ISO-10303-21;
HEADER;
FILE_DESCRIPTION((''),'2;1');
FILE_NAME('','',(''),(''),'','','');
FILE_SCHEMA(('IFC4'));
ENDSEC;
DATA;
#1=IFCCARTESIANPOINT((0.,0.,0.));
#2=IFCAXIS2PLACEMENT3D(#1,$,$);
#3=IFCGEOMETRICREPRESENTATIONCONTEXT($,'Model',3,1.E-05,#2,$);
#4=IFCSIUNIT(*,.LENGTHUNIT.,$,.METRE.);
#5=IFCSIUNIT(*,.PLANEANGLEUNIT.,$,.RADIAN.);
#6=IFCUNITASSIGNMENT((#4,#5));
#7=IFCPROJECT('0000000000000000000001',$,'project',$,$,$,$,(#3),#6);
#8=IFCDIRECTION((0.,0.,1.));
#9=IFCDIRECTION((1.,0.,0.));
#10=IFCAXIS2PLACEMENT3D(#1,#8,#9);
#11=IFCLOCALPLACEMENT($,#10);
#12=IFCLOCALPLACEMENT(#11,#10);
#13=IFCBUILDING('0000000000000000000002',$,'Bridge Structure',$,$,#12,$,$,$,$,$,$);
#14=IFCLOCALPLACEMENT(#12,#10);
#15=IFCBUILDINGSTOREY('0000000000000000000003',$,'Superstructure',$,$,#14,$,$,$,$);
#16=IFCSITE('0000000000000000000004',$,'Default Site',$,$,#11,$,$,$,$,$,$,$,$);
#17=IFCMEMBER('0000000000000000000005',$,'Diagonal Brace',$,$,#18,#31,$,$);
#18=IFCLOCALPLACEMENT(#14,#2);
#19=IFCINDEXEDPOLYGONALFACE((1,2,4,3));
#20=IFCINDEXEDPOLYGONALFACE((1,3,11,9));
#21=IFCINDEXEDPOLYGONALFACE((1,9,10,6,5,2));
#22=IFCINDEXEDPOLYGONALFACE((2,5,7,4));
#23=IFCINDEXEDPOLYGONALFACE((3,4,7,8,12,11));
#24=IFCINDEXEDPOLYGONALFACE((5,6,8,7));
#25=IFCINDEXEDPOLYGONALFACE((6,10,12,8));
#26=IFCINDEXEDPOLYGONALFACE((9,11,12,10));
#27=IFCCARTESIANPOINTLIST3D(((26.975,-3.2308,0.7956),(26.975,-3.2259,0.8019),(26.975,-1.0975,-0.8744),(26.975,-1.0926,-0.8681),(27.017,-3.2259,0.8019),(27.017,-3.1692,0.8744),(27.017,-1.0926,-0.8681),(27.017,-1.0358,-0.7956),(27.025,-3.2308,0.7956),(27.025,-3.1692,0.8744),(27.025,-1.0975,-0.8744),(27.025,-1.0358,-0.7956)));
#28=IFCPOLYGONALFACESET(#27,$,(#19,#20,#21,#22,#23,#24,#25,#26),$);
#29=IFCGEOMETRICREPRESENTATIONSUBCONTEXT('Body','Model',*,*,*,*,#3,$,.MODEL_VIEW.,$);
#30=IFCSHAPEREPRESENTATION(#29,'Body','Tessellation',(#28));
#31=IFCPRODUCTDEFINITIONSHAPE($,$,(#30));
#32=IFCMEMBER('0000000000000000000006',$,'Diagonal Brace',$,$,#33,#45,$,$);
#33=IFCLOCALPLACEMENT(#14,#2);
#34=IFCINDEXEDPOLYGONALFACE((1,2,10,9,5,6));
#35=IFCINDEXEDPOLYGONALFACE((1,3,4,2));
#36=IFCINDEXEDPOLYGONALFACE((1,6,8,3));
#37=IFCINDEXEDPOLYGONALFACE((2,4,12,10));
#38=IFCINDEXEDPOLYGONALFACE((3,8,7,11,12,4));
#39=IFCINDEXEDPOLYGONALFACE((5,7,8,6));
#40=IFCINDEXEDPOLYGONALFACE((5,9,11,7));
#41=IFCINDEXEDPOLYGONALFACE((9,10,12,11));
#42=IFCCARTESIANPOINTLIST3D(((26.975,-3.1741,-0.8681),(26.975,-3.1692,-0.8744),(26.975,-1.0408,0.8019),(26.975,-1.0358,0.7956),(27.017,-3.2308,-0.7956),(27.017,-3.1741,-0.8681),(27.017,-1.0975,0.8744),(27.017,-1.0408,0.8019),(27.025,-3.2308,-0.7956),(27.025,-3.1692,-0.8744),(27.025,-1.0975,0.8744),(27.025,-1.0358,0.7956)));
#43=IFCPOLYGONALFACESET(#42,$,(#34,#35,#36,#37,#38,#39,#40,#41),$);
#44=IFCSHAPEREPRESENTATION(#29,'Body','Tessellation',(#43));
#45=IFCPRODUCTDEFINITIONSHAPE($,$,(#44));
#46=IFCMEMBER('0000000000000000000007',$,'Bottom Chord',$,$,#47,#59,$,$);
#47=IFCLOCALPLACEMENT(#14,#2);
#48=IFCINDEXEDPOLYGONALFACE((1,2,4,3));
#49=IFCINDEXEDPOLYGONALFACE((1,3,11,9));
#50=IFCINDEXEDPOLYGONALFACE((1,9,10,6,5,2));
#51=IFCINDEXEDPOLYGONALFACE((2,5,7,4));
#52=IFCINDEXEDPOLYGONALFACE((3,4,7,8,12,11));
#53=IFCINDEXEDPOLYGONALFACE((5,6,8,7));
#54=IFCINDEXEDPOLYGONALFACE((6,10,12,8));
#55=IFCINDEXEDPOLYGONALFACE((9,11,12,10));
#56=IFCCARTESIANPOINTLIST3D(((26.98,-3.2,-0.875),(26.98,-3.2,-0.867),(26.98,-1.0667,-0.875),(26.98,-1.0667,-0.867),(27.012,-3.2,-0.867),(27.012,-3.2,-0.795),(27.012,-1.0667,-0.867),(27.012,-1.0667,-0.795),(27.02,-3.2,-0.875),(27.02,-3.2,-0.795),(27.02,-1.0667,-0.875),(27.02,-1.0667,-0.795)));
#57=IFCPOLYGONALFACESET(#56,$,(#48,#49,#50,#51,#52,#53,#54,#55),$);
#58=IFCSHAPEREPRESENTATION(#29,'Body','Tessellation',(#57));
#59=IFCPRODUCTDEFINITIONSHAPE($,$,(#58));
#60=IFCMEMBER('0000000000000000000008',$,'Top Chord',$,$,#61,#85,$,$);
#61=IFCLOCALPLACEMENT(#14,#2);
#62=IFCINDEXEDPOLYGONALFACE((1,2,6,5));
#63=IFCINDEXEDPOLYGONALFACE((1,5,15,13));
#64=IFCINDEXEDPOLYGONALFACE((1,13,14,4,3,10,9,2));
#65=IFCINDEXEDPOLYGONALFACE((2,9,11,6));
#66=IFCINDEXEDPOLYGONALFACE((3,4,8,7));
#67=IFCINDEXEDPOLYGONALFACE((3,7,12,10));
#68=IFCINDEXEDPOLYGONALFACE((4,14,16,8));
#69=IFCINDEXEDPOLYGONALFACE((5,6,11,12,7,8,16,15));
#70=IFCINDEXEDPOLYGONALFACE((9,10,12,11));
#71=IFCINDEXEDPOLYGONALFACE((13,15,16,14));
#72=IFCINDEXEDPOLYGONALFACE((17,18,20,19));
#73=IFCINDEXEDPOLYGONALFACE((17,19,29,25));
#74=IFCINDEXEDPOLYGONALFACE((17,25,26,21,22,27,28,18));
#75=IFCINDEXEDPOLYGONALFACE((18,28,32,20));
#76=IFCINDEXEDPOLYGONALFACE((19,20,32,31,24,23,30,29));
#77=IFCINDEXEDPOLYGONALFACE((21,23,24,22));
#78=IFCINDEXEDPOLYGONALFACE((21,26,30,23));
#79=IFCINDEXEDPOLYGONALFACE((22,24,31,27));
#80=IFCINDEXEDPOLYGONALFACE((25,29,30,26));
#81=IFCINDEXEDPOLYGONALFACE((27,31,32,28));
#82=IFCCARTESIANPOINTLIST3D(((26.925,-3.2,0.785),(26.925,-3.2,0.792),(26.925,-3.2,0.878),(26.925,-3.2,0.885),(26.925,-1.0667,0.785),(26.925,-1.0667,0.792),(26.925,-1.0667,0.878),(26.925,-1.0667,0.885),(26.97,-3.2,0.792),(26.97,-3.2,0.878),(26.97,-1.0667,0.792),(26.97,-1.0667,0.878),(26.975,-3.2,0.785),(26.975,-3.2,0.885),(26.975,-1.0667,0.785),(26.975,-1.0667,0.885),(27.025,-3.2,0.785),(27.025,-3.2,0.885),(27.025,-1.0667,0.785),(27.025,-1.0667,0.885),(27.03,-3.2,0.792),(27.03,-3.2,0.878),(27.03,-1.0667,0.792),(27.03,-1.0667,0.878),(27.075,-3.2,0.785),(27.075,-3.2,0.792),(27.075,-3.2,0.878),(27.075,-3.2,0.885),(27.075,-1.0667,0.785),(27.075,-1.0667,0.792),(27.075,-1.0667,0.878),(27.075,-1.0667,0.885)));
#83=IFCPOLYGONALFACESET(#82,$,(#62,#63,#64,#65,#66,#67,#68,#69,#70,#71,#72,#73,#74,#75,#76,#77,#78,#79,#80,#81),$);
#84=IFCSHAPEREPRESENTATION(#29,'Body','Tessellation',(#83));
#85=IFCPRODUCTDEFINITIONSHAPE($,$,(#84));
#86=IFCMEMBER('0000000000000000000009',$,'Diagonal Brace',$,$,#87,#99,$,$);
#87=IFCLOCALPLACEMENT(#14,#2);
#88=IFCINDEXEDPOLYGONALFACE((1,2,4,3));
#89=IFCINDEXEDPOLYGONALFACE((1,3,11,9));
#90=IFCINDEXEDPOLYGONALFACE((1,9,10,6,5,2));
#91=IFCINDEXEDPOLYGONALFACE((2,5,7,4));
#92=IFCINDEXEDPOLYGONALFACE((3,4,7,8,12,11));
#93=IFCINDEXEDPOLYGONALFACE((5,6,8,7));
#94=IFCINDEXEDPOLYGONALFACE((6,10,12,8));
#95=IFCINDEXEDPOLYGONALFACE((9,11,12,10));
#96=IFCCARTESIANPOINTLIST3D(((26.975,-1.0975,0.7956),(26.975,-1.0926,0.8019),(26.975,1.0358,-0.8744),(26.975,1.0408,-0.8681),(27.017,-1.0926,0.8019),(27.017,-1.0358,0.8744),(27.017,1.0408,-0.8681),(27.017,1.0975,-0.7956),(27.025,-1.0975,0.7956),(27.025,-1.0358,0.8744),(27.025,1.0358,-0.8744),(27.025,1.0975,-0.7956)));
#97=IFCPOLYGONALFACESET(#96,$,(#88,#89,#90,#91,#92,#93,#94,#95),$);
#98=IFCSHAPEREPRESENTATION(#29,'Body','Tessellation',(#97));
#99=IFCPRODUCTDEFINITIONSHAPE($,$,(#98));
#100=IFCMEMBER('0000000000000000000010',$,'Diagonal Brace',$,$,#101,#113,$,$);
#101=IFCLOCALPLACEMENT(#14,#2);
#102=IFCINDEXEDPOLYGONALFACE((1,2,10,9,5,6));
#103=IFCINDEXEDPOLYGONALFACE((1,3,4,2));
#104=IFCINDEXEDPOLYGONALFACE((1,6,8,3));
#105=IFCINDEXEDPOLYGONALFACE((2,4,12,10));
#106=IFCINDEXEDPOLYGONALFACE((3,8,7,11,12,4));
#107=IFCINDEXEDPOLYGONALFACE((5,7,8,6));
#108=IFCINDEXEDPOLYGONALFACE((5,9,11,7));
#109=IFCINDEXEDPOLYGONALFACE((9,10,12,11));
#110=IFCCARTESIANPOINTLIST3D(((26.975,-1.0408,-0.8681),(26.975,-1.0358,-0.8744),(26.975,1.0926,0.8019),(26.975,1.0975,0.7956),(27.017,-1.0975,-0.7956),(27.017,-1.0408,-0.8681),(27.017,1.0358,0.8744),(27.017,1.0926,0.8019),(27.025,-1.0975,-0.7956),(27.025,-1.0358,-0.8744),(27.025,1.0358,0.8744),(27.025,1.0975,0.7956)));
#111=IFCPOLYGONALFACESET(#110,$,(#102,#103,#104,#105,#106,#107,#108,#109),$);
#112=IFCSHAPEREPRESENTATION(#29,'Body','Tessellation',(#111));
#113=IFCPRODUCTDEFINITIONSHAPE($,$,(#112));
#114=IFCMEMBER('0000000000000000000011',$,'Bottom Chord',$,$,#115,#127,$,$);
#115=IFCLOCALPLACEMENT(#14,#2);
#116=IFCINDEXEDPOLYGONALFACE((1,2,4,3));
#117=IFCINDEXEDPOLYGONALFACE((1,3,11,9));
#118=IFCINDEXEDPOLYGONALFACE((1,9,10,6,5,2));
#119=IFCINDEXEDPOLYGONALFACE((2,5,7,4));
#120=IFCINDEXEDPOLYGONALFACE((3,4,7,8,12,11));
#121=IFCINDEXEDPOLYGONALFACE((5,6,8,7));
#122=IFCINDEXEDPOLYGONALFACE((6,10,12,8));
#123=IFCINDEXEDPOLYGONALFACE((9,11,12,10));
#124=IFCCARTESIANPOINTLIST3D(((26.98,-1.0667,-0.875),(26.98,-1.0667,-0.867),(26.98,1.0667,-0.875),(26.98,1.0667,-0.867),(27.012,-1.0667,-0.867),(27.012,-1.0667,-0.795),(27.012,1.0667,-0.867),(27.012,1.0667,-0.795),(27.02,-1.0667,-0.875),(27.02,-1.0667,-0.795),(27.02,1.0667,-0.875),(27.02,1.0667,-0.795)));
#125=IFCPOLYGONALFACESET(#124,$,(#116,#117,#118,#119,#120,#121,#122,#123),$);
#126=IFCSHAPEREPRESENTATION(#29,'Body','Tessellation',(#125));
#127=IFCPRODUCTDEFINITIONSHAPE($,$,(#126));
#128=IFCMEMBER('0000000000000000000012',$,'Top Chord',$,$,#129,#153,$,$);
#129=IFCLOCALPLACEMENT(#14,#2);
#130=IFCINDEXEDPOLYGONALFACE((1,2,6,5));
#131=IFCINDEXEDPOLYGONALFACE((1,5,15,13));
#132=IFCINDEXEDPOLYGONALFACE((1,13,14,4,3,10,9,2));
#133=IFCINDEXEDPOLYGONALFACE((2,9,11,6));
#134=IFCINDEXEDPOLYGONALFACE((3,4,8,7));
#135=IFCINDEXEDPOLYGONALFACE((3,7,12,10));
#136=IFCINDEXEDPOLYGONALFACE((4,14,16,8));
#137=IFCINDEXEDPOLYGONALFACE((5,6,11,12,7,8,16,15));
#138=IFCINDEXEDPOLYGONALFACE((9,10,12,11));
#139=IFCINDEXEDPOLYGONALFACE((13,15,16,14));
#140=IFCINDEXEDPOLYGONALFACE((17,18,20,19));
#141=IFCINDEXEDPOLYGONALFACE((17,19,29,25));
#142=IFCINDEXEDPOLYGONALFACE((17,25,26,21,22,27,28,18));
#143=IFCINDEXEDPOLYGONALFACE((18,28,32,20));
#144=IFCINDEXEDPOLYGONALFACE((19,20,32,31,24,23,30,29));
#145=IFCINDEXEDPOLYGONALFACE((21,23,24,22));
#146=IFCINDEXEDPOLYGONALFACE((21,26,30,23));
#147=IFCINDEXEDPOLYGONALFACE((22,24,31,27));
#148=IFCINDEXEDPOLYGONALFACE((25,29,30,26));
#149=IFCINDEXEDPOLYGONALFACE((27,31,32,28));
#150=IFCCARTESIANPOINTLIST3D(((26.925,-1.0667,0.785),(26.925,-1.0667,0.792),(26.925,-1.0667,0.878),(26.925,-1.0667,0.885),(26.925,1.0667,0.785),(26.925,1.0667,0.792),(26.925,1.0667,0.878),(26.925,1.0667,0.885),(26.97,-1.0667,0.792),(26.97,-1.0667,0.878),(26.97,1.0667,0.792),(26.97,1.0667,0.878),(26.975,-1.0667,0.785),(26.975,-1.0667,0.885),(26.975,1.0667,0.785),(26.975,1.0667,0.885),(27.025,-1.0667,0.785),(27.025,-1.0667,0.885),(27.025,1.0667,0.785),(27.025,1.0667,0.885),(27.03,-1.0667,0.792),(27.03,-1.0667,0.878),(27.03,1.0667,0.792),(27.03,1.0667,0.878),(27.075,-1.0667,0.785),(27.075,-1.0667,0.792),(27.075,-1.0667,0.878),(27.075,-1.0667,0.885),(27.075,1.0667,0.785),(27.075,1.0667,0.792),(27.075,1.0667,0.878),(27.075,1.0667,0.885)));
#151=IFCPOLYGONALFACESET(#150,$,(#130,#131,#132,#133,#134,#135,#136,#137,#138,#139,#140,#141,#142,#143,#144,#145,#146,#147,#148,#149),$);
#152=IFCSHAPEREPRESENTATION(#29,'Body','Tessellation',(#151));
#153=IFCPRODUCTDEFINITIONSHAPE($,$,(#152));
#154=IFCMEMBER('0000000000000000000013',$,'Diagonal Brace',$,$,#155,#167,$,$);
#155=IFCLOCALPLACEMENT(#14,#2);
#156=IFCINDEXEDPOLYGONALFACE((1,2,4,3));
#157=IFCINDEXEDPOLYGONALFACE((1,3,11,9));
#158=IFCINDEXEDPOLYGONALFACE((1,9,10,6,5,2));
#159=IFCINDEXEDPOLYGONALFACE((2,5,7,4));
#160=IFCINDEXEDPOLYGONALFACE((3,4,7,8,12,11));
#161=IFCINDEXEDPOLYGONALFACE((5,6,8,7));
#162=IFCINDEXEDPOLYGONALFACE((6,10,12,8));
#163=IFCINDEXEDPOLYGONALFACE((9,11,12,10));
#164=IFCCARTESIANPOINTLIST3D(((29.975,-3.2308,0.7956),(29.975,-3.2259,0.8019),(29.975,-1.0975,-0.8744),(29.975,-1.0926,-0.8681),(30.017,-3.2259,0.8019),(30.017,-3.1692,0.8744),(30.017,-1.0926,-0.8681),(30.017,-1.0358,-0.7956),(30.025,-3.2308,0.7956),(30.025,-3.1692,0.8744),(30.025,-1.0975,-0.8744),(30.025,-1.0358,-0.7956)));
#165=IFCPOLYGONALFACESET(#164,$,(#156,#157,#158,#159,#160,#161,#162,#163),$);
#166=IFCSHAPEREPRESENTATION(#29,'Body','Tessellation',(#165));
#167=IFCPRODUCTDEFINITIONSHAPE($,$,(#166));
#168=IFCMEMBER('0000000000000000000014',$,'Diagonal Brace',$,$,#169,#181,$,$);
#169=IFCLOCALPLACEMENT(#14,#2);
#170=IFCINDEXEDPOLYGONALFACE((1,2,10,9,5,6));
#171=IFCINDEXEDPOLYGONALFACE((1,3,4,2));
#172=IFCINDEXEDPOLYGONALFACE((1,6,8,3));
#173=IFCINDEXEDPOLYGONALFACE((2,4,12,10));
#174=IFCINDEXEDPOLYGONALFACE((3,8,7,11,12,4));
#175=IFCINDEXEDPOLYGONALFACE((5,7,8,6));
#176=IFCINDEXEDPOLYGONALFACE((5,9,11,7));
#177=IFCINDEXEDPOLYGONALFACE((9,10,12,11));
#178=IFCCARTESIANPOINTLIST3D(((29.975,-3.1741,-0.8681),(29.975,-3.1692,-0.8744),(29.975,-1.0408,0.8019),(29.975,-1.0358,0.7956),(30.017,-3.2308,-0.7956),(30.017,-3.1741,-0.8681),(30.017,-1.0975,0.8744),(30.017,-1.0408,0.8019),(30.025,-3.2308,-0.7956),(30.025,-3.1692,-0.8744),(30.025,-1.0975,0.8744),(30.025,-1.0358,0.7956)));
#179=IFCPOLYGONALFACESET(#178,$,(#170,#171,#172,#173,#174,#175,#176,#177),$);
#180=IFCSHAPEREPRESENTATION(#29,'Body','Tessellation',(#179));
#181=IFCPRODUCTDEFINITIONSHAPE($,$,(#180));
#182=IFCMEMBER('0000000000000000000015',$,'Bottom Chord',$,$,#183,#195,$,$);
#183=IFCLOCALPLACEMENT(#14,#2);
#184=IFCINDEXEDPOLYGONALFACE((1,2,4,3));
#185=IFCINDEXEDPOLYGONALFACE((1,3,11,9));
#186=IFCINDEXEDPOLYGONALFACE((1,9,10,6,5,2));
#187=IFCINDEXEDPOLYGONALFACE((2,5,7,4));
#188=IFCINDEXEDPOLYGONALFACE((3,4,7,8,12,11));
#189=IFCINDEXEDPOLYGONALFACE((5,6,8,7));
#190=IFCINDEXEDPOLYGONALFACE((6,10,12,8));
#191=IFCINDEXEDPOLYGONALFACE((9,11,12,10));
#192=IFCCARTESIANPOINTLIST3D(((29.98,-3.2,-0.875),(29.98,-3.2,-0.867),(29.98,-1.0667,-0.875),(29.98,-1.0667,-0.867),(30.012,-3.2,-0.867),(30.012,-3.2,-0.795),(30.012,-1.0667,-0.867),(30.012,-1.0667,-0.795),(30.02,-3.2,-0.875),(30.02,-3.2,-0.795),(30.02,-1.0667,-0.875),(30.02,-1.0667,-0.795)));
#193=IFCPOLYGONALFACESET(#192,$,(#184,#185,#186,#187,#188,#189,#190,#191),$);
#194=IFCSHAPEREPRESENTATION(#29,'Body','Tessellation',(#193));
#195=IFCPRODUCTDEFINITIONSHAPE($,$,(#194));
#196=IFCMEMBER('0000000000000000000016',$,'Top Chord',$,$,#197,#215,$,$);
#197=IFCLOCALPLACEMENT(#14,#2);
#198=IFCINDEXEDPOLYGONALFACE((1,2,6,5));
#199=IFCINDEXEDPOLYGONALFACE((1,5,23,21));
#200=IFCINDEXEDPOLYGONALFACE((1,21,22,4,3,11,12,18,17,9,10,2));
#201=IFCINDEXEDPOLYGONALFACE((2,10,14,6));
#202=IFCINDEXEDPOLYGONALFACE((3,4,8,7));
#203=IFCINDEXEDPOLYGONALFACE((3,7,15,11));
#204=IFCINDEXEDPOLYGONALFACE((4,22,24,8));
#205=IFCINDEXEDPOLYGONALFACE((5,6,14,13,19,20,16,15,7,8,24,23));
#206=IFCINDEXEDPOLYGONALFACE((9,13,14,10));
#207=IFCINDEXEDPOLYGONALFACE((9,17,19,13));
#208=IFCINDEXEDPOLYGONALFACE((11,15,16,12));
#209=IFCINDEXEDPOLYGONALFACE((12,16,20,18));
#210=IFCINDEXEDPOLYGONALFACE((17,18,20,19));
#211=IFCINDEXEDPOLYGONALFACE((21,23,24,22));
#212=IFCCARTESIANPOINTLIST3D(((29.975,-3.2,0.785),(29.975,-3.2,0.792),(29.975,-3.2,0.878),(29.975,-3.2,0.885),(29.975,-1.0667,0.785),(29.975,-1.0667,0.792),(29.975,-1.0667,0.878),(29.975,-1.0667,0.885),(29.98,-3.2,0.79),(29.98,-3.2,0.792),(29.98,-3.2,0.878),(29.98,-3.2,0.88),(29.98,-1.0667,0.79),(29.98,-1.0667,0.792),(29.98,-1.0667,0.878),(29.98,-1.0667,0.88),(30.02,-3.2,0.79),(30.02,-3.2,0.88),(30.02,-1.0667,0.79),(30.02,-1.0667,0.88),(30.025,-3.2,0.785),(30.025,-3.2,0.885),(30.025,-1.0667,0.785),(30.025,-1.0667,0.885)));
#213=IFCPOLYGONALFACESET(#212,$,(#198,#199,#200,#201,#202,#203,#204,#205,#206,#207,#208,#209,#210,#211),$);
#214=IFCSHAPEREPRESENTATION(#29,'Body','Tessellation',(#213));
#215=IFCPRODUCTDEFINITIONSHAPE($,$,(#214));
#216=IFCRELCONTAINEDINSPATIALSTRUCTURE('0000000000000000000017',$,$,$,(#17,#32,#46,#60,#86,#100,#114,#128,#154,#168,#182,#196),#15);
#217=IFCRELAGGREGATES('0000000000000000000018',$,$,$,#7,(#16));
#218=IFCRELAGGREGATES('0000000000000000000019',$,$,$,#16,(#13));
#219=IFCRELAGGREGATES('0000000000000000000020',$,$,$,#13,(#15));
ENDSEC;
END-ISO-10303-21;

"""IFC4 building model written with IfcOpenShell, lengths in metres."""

from ifc_helpers import new_model, si_unit, frame, origin, origin_with_axes, origin_2d_with_axis, place, context, subcontext, project, spatial, polyline, l_section, c_section, outline, composite_profile, extrude, element, save


model = new_model("IFC4")

# Units and contexts
model_context = context("Model", 3, precision=1e-05, world=origin())
body_context = subcontext(model_context, "Body", "Model", "MODEL_VIEW")
ifc_project = project(units=[si_unit("LENGTHUNIT", "METRE"), si_unit("PLANEANGLEUNIT", "RADIAN")], contexts=[model_context])

# Site, building, storey
site_placement = place(None, origin_with_axes())
site = spatial("IfcSite", under=ifc_project, at=site_placement, Name="Default Site")
building_placement = place(site_placement, origin_with_axes())
building = spatial("IfcBuilding", under=site, at=building_placement, Name="Bridge Structure")
storey_placement = place(building_placement, origin_with_axes())
storey = spatial("IfcBuildingStorey", under=building, at=storey_placement, Name="Superstructure")

# Members
for number, where, z_axis, x_axis, name in (
    (1, (27.0, -3.2, 0.835), (0.0, 0.787427, -0.616408), (-1.0, 0.0, 0.0), "Diagonal Brace"),
    (2, (27.0, -3.2, -0.835), (0.0, 0.787427, 0.616408), (-1.0, 0.0, 0.0), "Diagonal Brace"),
):
    element("IfcMember", number, at=place(storey_placement, frame(where, z_axis=z_axis, x_axis=x_axis)), inside=storey, Name=name, context=body_context, shape_type="SweptSolid", body=[
        extrude(l_section(Depth=0.1, Width=0.05, Thickness=0.008, at=origin_2d_with_axis()), origin_with_axes(), (0.0, 0.0, 1.0), 2.7092),
    ])
member_1_placement = place(storey_placement, frame((27.0, -3.2, -0.835), z_axis=(0.0, 1.0, 0.0), x_axis=(-1.0, 0.0, 0.0)))
element("IfcMember", 3, at=member_1_placement, inside=storey, Name="Bottom Chord", context=body_context, shape_type="SweptSolid", body=[
    extrude(l_section(Depth=0.08, Width=0.04, Thickness=0.008, at=origin_2d_with_axis()), origin_with_axes(), (0.0, 0.0, 1.0), 2.1333),
])
member_2_placement = place(storey_placement, frame((27.0, -3.2, 0.835), z_axis=(0.0, 1.0, 0.0), x_axis=(-1.0, 0.0, 0.0)))
element("IfcMember", 4, at=member_2_placement, inside=storey, Name="Top Chord", context=body_context, shape_type="SweptSolid", body=[
    extrude(composite_profile([outline(polyline([(-0.025, -0.05), (-0.025, 0.05), (-0.075, 0.05), (-0.075, 0.043), (-0.03, 0.043), (-0.03, -0.043), (-0.075, -0.043), (-0.075, -0.05), (-0.025, -0.05)])), outline(polyline([(0.025, -0.05), (0.075, -0.05), (0.075, -0.043), (0.03, -0.043), (0.03, 0.043), (0.075, 0.043), (0.075, 0.05), (0.025, 0.05), (0.025, -0.05)]))]), origin_with_axes(), (0.0, 0.0, 1.0), 2.1333),
])
for number, where, z_axis, x_axis, name in (
    (5, (27.0, -1.0667, 0.835), (0.0, 0.787427, -0.616408), (-1.0, 0.0, 0.0), "Diagonal Brace"),
    (6, (27.0, -1.0667, -0.835), (0.0, 0.787427, 0.616408), (-1.0, 0.0, 0.0), "Diagonal Brace"),
):
    element("IfcMember", number, at=place(storey_placement, frame(where, z_axis=z_axis, x_axis=x_axis)), inside=storey, Name=name, context=body_context, shape_type="SweptSolid", body=[
        extrude(l_section(Depth=0.1, Width=0.05, Thickness=0.008, at=origin_2d_with_axis()), origin_with_axes(), (0.0, 0.0, 1.0), 2.7092),
    ])
member_3_placement = place(storey_placement, frame((27.0, -1.0667, -0.835), z_axis=(0.0, 1.0, 0.0), x_axis=(-1.0, 0.0, 0.0)))
element("IfcMember", 7, at=member_3_placement, inside=storey, Name="Bottom Chord", context=body_context, shape_type="SweptSolid", body=[
    extrude(l_section(Depth=0.08, Width=0.04, Thickness=0.008, at=origin_2d_with_axis()), origin_with_axes(), (0.0, 0.0, 1.0), 2.1333),
])
member_4_placement = place(storey_placement, frame((27.0, -1.0667, 0.835), z_axis=(0.0, 1.0, 0.0), x_axis=(-1.0, 0.0, 0.0)))
element("IfcMember", 8, at=member_4_placement, inside=storey, Name="Top Chord", context=body_context, shape_type="SweptSolid", body=[
    extrude(composite_profile([outline(polyline([(-0.025, -0.05), (-0.025, 0.05), (-0.075, 0.05), (-0.075, 0.043), (-0.03, 0.043), (-0.03, -0.043), (-0.075, -0.043), (-0.075, -0.05), (-0.025, -0.05)])), outline(polyline([(0.025, -0.05), (0.075, -0.05), (0.075, -0.043), (0.03, -0.043), (0.03, 0.043), (0.075, 0.043), (0.075, 0.05), (0.025, 0.05), (0.025, -0.05)]))]), origin_with_axes(), (0.0, 0.0, 1.0), 2.1333),
])
for number, where, z_axis, x_axis, name in (
    (9, (30.0, -3.2, 0.835), (0.0, 0.787427, -0.616408), (-1.0, 0.0, 0.0), "Diagonal Brace"),
    (10, (30.0, -3.2, -0.835), (0.0, 0.787427, 0.616408), (-1.0, 0.0, 0.0), "Diagonal Brace"),
):
    element("IfcMember", number, at=place(storey_placement, frame(where, z_axis=z_axis, x_axis=x_axis)), inside=storey, Name=name, context=body_context, shape_type="SweptSolid", body=[
        extrude(l_section(Depth=0.1, Width=0.05, Thickness=0.008, at=origin_2d_with_axis()), origin_with_axes(), (0.0, 0.0, 1.0), 2.7092),
    ])
member_5_placement = place(storey_placement, frame((30.0, -3.2, -0.835), z_axis=(0.0, 1.0, 0.0), x_axis=(-1.0, 0.0, 0.0)))
element("IfcMember", 11, at=member_5_placement, inside=storey, Name="Bottom Chord", context=body_context, shape_type="SweptSolid", body=[
    extrude(l_section(Depth=0.08, Width=0.04, Thickness=0.008, at=origin_2d_with_axis()), origin_with_axes(), (0.0, 0.0, 1.0), 2.1333),
])
member_6_placement = place(storey_placement, frame((30.0, -3.2, 0.835), z_axis=(0.0, 1.0, 0.0), x_axis=(-1.0, 0.0, 0.0)))
element("IfcMember", 12, at=member_6_placement, inside=storey, Name="Top Chord", context=body_context, shape_type="SweptSolid", body=[
    extrude(c_section(Depth=0.1, Width=0.05, WallThickness=0.005, Girth=0.007, at=origin_2d_with_axis()), origin_with_axes(), (0.0, 0.0, 1.0), 2.1333),
])

save(model, "model.ifc")
